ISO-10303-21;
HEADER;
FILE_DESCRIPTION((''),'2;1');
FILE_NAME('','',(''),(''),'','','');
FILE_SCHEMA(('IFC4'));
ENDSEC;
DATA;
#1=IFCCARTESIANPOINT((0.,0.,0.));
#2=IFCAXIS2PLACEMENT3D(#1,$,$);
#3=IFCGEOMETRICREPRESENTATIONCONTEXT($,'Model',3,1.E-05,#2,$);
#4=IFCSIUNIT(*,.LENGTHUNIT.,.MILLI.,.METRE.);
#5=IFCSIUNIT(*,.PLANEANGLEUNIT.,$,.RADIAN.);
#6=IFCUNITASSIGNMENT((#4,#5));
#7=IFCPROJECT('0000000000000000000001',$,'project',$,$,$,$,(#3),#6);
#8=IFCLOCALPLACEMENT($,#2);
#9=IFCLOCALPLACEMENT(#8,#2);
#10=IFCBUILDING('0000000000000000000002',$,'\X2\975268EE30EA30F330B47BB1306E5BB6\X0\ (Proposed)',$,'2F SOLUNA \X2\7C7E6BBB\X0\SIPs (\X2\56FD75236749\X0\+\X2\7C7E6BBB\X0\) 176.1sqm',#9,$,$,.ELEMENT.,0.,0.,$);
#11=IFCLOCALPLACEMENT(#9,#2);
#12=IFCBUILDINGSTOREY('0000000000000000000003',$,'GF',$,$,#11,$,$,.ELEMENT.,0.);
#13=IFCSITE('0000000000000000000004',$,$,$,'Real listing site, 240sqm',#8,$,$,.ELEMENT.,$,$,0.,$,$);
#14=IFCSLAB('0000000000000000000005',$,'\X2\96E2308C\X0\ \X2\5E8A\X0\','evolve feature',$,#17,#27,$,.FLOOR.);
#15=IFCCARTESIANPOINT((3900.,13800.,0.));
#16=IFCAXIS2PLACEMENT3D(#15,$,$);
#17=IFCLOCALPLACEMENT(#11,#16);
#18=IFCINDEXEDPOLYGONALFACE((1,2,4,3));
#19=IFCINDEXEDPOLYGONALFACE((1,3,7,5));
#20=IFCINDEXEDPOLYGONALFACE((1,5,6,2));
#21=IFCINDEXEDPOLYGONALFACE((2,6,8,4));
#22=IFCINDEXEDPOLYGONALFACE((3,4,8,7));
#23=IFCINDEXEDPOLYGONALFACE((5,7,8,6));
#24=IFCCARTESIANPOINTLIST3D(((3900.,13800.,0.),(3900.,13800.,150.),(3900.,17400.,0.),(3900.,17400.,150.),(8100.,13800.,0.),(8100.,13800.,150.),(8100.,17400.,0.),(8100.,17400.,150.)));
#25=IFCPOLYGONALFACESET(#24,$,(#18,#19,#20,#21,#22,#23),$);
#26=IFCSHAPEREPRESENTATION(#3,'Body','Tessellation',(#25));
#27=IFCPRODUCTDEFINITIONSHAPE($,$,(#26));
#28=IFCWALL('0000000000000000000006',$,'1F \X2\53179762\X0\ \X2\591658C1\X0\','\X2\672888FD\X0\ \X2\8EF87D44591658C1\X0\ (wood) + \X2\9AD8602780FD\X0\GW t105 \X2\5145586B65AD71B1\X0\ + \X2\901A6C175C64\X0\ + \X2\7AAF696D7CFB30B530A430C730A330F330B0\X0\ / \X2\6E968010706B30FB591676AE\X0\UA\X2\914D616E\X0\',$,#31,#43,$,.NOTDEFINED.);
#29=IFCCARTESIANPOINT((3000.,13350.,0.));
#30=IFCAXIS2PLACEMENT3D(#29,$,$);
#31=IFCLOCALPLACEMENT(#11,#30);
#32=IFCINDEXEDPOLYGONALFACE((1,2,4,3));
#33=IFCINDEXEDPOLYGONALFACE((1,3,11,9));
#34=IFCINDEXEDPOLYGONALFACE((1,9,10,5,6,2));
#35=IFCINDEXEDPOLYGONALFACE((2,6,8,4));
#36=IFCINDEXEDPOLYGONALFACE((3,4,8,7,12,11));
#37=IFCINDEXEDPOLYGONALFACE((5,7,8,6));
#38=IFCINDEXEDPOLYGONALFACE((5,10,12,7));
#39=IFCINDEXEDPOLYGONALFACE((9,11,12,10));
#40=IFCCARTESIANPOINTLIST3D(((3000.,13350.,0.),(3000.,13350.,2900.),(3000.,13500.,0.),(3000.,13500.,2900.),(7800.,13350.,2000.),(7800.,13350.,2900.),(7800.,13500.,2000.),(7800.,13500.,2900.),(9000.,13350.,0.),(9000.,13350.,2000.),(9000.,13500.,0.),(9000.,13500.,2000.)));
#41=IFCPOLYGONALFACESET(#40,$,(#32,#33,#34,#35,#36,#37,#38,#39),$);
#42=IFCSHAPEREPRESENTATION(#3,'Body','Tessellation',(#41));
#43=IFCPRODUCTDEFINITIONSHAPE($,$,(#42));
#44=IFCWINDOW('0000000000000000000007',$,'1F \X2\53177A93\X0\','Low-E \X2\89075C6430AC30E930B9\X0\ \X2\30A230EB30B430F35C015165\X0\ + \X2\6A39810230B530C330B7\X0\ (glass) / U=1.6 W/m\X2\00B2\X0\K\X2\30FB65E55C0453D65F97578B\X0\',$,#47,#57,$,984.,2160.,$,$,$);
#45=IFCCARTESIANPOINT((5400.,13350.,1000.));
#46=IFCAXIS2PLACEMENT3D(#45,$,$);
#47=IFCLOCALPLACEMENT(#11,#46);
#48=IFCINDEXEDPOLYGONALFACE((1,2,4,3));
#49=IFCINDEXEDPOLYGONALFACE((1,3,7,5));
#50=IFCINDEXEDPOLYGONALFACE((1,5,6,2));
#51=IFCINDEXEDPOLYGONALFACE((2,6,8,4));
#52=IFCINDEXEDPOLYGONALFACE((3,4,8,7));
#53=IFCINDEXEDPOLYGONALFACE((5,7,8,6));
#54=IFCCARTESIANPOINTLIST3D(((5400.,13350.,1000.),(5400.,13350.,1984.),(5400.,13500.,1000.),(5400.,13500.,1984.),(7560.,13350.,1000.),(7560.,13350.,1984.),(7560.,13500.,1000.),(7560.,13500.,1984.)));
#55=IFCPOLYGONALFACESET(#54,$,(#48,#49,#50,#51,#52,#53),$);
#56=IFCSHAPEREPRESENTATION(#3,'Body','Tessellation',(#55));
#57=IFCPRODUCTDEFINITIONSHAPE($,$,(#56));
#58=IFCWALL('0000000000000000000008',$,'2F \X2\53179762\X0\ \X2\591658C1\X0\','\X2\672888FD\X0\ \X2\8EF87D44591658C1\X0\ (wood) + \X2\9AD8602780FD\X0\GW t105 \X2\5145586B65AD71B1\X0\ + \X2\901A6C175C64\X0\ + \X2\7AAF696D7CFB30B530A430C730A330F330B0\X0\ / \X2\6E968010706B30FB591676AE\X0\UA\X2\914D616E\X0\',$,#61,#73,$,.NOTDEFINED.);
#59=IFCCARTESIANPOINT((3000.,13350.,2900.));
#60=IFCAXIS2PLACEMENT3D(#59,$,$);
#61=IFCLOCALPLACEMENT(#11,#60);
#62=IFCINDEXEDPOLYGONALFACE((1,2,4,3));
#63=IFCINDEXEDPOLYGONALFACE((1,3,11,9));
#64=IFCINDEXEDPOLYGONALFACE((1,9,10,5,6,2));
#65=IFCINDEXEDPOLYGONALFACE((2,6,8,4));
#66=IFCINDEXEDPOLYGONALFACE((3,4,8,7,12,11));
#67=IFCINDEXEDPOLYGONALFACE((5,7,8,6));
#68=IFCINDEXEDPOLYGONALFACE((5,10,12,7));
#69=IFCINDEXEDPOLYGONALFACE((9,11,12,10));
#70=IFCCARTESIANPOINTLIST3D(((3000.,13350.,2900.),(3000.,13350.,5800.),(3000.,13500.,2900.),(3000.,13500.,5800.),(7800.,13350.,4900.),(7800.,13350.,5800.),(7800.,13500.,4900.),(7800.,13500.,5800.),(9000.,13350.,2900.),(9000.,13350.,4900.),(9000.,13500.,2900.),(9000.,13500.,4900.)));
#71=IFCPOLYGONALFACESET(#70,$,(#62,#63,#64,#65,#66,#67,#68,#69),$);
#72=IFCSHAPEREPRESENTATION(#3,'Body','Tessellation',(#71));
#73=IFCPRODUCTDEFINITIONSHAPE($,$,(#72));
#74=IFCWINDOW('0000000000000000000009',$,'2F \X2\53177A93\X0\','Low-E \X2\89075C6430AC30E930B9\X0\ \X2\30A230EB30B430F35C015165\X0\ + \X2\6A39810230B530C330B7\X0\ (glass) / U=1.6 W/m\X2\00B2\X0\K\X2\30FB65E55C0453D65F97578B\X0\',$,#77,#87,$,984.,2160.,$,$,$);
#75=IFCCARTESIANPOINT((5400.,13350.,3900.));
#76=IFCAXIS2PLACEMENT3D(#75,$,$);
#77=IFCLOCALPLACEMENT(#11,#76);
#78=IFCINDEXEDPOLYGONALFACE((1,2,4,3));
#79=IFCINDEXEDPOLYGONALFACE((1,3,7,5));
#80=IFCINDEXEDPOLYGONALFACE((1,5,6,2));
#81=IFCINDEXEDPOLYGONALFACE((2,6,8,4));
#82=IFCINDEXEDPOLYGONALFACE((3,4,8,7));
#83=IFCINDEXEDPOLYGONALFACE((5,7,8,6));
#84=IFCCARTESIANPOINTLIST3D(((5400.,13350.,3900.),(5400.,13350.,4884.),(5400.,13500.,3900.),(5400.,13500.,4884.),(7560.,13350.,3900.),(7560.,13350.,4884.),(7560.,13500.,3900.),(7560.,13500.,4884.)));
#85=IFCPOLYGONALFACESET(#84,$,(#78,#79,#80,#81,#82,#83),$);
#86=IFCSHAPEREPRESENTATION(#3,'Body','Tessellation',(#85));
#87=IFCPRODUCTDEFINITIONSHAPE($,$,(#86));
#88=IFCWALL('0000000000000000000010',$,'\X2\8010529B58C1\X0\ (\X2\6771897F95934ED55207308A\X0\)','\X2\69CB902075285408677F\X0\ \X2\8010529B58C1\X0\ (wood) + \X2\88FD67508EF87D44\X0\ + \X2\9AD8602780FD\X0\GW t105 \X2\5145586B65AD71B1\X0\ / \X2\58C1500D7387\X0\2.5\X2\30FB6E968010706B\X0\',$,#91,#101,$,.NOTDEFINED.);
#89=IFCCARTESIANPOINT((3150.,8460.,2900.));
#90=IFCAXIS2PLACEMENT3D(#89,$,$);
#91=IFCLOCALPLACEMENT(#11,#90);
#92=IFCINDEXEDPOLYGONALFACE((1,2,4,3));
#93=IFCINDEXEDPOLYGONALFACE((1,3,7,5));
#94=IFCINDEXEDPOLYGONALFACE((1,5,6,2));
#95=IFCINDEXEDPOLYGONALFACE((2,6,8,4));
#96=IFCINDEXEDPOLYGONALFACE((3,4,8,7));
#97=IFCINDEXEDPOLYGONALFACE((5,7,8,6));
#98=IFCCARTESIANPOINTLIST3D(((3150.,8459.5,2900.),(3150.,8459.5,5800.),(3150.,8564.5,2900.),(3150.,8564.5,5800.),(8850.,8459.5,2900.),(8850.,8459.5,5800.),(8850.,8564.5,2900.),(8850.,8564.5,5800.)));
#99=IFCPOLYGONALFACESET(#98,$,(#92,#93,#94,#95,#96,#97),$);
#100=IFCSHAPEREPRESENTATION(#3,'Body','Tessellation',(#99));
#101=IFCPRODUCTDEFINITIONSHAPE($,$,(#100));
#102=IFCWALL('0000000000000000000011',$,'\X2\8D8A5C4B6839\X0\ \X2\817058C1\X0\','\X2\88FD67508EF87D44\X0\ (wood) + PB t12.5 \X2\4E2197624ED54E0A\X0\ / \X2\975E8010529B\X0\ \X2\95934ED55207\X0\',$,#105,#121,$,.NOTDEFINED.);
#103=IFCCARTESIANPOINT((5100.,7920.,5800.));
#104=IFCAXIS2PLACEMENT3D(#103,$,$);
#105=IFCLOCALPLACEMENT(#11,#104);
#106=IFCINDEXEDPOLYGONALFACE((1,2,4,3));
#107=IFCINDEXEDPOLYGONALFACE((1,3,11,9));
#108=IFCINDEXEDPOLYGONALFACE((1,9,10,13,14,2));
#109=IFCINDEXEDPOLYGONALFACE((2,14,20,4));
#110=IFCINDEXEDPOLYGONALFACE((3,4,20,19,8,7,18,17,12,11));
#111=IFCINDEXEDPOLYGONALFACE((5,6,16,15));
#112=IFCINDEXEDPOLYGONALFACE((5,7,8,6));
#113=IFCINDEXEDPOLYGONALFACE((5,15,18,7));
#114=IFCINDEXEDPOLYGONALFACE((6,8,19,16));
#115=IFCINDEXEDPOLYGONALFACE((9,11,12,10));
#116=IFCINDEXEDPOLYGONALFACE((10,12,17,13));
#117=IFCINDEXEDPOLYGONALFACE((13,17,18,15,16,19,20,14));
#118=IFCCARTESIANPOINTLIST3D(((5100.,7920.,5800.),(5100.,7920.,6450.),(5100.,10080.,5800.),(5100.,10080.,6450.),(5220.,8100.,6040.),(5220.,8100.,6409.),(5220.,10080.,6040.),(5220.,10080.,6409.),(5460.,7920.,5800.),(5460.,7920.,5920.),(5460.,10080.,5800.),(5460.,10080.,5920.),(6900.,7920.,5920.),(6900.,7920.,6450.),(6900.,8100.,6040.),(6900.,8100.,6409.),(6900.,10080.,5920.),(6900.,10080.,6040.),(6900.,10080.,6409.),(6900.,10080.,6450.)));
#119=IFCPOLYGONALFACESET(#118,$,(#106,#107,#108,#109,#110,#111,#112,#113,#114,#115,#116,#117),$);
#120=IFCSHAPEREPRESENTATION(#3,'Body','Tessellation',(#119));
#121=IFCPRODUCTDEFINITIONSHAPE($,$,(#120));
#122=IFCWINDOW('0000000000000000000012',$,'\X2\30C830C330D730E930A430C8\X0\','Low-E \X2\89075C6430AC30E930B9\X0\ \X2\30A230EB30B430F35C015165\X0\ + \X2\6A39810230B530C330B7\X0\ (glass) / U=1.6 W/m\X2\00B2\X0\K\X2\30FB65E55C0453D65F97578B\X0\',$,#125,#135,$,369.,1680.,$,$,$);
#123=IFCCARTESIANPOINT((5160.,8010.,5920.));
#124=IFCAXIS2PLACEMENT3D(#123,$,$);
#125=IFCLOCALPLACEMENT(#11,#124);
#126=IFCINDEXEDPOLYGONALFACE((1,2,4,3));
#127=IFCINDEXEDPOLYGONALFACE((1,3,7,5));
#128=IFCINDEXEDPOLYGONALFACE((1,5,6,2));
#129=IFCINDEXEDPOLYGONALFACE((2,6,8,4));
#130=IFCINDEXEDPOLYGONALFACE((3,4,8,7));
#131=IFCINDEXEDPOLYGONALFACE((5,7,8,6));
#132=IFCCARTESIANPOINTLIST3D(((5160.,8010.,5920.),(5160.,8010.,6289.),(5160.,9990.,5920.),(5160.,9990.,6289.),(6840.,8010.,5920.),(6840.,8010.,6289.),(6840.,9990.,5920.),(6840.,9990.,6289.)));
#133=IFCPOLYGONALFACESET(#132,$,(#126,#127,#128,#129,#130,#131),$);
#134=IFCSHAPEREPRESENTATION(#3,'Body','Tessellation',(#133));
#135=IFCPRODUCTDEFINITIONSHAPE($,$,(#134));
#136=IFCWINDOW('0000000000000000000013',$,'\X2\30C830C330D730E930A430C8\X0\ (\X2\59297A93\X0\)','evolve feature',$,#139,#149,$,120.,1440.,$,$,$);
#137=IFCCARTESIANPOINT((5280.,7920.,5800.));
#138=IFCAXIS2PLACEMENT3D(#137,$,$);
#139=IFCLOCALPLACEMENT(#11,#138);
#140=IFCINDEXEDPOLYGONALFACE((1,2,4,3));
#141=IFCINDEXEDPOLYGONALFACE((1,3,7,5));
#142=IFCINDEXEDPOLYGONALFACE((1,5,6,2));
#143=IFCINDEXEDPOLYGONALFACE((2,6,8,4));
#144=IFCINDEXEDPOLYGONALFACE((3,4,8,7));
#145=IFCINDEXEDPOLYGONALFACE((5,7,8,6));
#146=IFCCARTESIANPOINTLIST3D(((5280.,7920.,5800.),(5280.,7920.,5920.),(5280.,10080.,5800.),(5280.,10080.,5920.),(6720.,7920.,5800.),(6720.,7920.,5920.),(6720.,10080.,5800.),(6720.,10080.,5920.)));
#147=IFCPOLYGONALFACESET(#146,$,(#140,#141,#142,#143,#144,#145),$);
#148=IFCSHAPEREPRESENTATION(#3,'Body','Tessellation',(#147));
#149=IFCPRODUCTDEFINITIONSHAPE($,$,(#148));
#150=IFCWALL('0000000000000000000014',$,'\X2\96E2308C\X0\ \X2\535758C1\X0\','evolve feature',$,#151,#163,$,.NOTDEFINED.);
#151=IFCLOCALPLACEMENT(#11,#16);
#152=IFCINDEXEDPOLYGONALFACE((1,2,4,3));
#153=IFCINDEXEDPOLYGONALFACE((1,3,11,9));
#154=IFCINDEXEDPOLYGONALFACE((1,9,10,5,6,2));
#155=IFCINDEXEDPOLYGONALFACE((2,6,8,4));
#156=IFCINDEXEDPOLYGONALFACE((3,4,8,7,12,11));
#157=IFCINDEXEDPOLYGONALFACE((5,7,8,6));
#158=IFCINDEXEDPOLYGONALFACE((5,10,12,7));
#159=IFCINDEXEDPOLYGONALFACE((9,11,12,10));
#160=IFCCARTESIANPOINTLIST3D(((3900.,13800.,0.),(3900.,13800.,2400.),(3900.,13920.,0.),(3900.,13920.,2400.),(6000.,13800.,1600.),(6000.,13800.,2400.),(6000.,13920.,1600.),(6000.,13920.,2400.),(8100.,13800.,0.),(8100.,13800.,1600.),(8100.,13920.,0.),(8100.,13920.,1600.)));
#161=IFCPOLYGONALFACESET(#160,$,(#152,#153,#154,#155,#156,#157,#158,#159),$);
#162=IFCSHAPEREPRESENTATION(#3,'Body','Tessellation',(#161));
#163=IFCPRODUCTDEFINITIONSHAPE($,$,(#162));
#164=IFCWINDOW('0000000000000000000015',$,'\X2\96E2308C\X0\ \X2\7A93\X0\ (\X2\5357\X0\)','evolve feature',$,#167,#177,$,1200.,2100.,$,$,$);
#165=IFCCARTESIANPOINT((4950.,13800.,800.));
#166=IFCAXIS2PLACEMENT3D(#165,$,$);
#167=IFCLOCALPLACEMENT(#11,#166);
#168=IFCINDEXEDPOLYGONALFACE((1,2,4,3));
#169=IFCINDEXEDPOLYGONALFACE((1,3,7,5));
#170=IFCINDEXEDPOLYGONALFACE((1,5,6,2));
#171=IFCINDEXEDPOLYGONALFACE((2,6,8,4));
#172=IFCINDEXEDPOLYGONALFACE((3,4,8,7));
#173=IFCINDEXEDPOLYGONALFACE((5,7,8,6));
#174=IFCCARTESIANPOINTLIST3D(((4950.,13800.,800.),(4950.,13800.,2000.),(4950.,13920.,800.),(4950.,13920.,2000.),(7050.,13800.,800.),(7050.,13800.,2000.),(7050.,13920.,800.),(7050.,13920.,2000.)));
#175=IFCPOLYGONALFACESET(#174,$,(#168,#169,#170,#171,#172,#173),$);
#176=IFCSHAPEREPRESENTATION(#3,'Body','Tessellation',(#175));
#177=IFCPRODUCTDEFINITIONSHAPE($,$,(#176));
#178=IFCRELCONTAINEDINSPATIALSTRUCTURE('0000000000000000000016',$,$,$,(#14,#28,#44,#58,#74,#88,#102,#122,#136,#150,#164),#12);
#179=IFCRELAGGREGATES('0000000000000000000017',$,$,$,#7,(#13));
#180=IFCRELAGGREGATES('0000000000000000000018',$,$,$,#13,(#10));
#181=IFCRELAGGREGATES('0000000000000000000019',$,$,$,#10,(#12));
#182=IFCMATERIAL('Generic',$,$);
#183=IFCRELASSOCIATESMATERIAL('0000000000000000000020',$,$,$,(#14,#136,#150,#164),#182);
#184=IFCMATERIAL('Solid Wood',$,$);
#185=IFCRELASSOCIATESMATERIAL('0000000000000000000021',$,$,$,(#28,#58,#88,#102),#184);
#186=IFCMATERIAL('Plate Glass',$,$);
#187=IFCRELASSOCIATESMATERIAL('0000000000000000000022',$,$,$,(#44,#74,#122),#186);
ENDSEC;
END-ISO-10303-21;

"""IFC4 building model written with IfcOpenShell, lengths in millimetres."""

from ifc_helpers import new_model, si_unit, frame, frame_2d, origin, place, context, project, spatial, rectangle, extrude, material, element, fill, save


model = new_model("IFC4")

# Units and contexts
model_context = context("Model", 3, precision=1e-05, world=origin())
ifc_project = project(units=[si_unit("LENGTHUNIT", "METRE", prefix="MILLI"), si_unit("PLANEANGLEUNIT", "RADIAN")], contexts=[model_context])

# Site, building, storey
site_placement = place(None, origin())
site = spatial("IfcSite", under=ifc_project, at=site_placement, ObjectType="Real listing site, 240sqm", CompositionType="ELEMENT", RefElevation=0.0)
building_placement = place(site_placement, origin())
building = spatial("IfcBuilding", under=site, at=building_placement, Name="青森リンゴ箱の家 (Proposed)", ObjectType="2F SOLUNA 籾殻SIPs (国産杉+籾殻) 176.1sqm", CompositionType="ELEMENT", ElevationOfRefHeight=0.0, ElevationOfTerrain=0.0)
storey_placement = place(building_placement, origin())
storey = spatial("IfcBuildingStorey", under=building, at=storey_placement, Name="GF", CompositionType="ELEMENT", Elevation=0.0)

# Slab
ifc_material_1 = material(Name="Generic")
slab_placement = place(storey_placement, frame((3900.0, 13800.0, 0.0)))
element("IfcSlab", 1, at=slab_placement, inside=storey, material=ifc_material_1, Name="離れ 床", Description="evolve feature", PredefinedType="FLOOR", context=model_context, shape_type="SweptSolid", body=[
    extrude(rectangle(XDim=4200.0, YDim=3600.0, at=frame_2d((2100.0, 1800.0))), frame((3900.0, 13800.0, 0.0)), (0.0, 0.0, 1.0), 150.0),
])

# Wall, opening, window
ifc_material_2 = material(Name="Solid Wood")
wall_1_placement = place(storey_placement, frame((3000.0, 13350.0, 0.0)))
wall_1 = element("IfcWall", 2, at=wall_1_placement, inside=storey, material=ifc_material_2, Name="1F 北面 外壁", Description="木製 軸組外壁 (wood) + 高性能GW t105 充填断熱 + 通気層 + 窯業系サイディング / 準耐火・外皮UA配慮", PredefinedType="NOTDEFINED", context=model_context, shape_type="SweptSolid", body=[
    extrude(rectangle(XDim=6000.0, YDim=150.0, at=frame_2d((3000.0, 75.0))), frame((3000.0, 13350.0, 0.0)), (0.0, 0.0, 1.0), 2900.0),
])
opening_1_placement = place(storey_placement, frame((5400.0, 13350.0, 1000.0)))
opening_1 = element("IfcOpeningElement", 3, at=opening_1_placement, cuts=wall_1, PredefinedType="NOTDEFINED", context=model_context, shape_type="SweptSolid", body=[
    extrude(rectangle(XDim=2160.0, YDim=150.0, at=frame_2d((1080.0, 75.0))), frame((5400.0, 13350.0, 1000.0)), (0.0, 0.0, 1.0), 984.0),
])
ifc_material_3 = material(Name="Plate Glass")
window_1_placement = place(storey_placement, frame((5400.0, 13350.0, 1000.0)))
window_1 = element("IfcWindow", 4, at=window_1_placement, inside=storey, material=ifc_material_3, Name="1F 北窓", Description="Low-E 複層ガラス アルゴン封入 + 樹脂サッシ (glass) / U=1.6 W/m²K・日射取得型", OverallHeight=984.0, OverallWidth=2160.0, context=model_context, shape_type="SweptSolid", body=[
    extrude(rectangle(XDim=2160.0, YDim=150.0, at=frame_2d((1080.0, 75.0))), frame((5400.0, 13350.0, 1000.0)), (0.0, 0.0, 1.0), 984.0),
])
fill(opening_1, window_1)

# Wall, opening, window
wall_2_placement = place(storey_placement, frame((3000.0, 13350.0, 2900.0)))
wall_2 = element("IfcWall", 5, at=wall_2_placement, inside=storey, material=ifc_material_2, Name="2F 北面 外壁", Description="木製 軸組外壁 (wood) + 高性能GW t105 充填断熱 + 通気層 + 窯業系サイディング / 準耐火・外皮UA配慮", PredefinedType="NOTDEFINED", context=model_context, shape_type="SweptSolid", body=[
    extrude(rectangle(XDim=6000.0, YDim=150.0, at=frame_2d((3000.0, 75.0))), frame((3000.0, 13350.0, 2900.0)), (0.0, 0.0, 1.0), 2900.0),
])
opening_2_placement = place(storey_placement, frame((5400.0, 13350.0, 3900.0)))
opening_2 = element("IfcOpeningElement", 6, at=opening_2_placement, cuts=wall_2, PredefinedType="NOTDEFINED", context=model_context, shape_type="SweptSolid", body=[
    extrude(rectangle(XDim=2160.0, YDim=150.0, at=frame_2d((1080.0, 75.0))), frame((5400.0, 13350.0, 3900.0)), (0.0, 0.0, 1.0), 984.0),
])
window_2_placement = place(storey_placement, frame((5400.0, 13350.0, 3900.0)))
window_2 = element("IfcWindow", 7, at=window_2_placement, inside=storey, material=ifc_material_3, Name="2F 北窓", Description="Low-E 複層ガラス アルゴン封入 + 樹脂サッシ (glass) / U=1.6 W/m²K・日射取得型", OverallHeight=984.0, OverallWidth=2160.0, context=model_context, shape_type="SweptSolid", body=[
    extrude(rectangle(XDim=2160.0, YDim=150.0, at=frame_2d((1080.0, 75.0))), frame((5400.0, 13350.0, 3900.0)), (0.0, 0.0, 1.0), 984.0),
])
fill(opening_2, window_2)

# Wall
wall_3_placement = place(storey_placement, frame((3150.0, 8460.0, 2900.0)))
element("IfcWall", 8, at=wall_3_placement, inside=storey, material=ifc_material_2, Name="耐力壁 (東西間仕切り)", Description="構造用合板 耐力壁 (wood) + 製材軸組 + 高性能GW t105 充填断熱 / 壁倍率2.5・準耐火", PredefinedType="NOTDEFINED", context=model_context, shape_type="SweptSolid", body=[
    extrude(rectangle(XDim=5700.0, YDim=105.0, at=frame_2d((2850.0, 52.0))), frame((3150.0, 8460.0, 2900.0)), (0.0, 0.0, 1.0), 2900.0),
])

# Wall, openings, windows
wall_4_placement = place(storey_placement, frame((5100.0, 7920.0, 5800.0)))
wall_4 = element("IfcWall", 9, at=wall_4_placement, inside=storey, material=ifc_material_2, Name="越屋根 腰壁", Description="製材軸組 (wood) + PB t12.5 両面仕上 / 非耐力 間仕切", PredefinedType="NOTDEFINED", context=model_context, shape_type="SweptSolid", body=[
    extrude(rectangle(XDim=1800.0, YDim=2160.0, at=frame_2d((900.0, 1080.0))), frame((5100.0, 7920.0, 5800.0)), (0.0, 0.0, 1.0), 650.0),
])
opening_3_placement = place(storey_placement, frame((5160.0, 8010.0, 5920.0)))
opening_3 = element("IfcOpeningElement", 10, at=opening_3_placement, cuts=wall_4, PredefinedType="NOTDEFINED", context=model_context, shape_type="SweptSolid", body=[
    extrude(rectangle(XDim=1680.0, YDim=1980.0, at=frame_2d((840.0, 990.0))), frame((5160.0, 8010.0, 5920.0)), (0.0, 0.0, 1.0), 369.0),
])
opening_4_placement = place(storey_placement, frame((5280.0, 7920.0, 5800.0)))
opening_4 = element("IfcOpeningElement", 11, at=opening_4_placement, cuts=wall_4, PredefinedType="NOTDEFINED", context=model_context, shape_type="SweptSolid", body=[
    extrude(rectangle(XDim=1440.0, YDim=2160.0, at=frame_2d((720.0, 1080.0))), frame((5280.0, 7920.0, 5800.0)), (0.0, 0.0, 1.0), 120.0),
])
window_3_placement = place(storey_placement, frame((5160.0, 8010.0, 5920.0)))
window_3 = element("IfcWindow", 12, at=window_3_placement, inside=storey, material=ifc_material_3, Name="トップライト", Description="Low-E 複層ガラス アルゴン封入 + 樹脂サッシ (glass) / U=1.6 W/m²K・日射取得型", OverallHeight=369.0, OverallWidth=1680.0, context=model_context, shape_type="SweptSolid", body=[
    extrude(rectangle(XDim=1680.0, YDim=1980.0, at=frame_2d((840.0, 990.0))), frame((5160.0, 8010.0, 5920.0)), (0.0, 0.0, 1.0), 369.0),
])
fill(opening_3, window_3)
window_4_placement = place(storey_placement, frame((5280.0, 7920.0, 5800.0)))
window_4 = element("IfcWindow", 13, at=window_4_placement, inside=storey, material=ifc_material_1, Name="トップライト (天窓)", Description="evolve feature", OverallHeight=120.0, OverallWidth=1440.0, context=model_context, shape_type="SweptSolid", body=[
    extrude(rectangle(XDim=1440.0, YDim=2160.0, at=frame_2d((720.0, 1080.0))), frame((5280.0, 7920.0, 5800.0)), (0.0, 0.0, 1.0), 120.0),
])
fill(opening_4, window_4)

# Wall, opening, window
wall_5_placement = place(storey_placement, frame((3900.0, 13800.0, 0.0)))
wall_5 = element("IfcWall", 14, at=wall_5_placement, inside=storey, material=ifc_material_1, Name="離れ 南壁", Description="evolve feature", PredefinedType="NOTDEFINED", context=model_context, shape_type="SweptSolid", body=[
    extrude(rectangle(XDim=4200.0, YDim=120.0, at=frame_2d((2100.0, 60.0))), frame((3900.0, 13800.0, 0.0)), (0.0, 0.0, 1.0), 2400.0),
])
opening_5_placement = place(storey_placement, frame((4950.0, 13800.0, 800.0)))
opening_5 = element("IfcOpeningElement", 15, at=opening_5_placement, cuts=wall_5, PredefinedType="NOTDEFINED", context=model_context, shape_type="SweptSolid", body=[
    extrude(rectangle(XDim=2100.0, YDim=120.0, at=frame_2d((1050.0, 60.0))), frame((4950.0, 13800.0, 800.0)), (0.0, 0.0, 1.0), 1200.0),
])
window_5_placement = place(storey_placement, frame((4950.0, 13800.0, 800.0)))
window_5 = element("IfcWindow", 16, at=window_5_placement, inside=storey, material=ifc_material_1, Name="離れ 窓 (南)", Description="evolve feature", OverallHeight=1200.0, OverallWidth=2100.0, context=model_context, shape_type="SweptSolid", body=[
    extrude(rectangle(XDim=2100.0, YDim=120.0, at=frame_2d((1050.0, 60.0))), frame((4950.0, 13800.0, 800.0)), (0.0, 0.0, 1.0), 1200.0),
])
fill(opening_5, window_5)

save(model, "model.ifc")
